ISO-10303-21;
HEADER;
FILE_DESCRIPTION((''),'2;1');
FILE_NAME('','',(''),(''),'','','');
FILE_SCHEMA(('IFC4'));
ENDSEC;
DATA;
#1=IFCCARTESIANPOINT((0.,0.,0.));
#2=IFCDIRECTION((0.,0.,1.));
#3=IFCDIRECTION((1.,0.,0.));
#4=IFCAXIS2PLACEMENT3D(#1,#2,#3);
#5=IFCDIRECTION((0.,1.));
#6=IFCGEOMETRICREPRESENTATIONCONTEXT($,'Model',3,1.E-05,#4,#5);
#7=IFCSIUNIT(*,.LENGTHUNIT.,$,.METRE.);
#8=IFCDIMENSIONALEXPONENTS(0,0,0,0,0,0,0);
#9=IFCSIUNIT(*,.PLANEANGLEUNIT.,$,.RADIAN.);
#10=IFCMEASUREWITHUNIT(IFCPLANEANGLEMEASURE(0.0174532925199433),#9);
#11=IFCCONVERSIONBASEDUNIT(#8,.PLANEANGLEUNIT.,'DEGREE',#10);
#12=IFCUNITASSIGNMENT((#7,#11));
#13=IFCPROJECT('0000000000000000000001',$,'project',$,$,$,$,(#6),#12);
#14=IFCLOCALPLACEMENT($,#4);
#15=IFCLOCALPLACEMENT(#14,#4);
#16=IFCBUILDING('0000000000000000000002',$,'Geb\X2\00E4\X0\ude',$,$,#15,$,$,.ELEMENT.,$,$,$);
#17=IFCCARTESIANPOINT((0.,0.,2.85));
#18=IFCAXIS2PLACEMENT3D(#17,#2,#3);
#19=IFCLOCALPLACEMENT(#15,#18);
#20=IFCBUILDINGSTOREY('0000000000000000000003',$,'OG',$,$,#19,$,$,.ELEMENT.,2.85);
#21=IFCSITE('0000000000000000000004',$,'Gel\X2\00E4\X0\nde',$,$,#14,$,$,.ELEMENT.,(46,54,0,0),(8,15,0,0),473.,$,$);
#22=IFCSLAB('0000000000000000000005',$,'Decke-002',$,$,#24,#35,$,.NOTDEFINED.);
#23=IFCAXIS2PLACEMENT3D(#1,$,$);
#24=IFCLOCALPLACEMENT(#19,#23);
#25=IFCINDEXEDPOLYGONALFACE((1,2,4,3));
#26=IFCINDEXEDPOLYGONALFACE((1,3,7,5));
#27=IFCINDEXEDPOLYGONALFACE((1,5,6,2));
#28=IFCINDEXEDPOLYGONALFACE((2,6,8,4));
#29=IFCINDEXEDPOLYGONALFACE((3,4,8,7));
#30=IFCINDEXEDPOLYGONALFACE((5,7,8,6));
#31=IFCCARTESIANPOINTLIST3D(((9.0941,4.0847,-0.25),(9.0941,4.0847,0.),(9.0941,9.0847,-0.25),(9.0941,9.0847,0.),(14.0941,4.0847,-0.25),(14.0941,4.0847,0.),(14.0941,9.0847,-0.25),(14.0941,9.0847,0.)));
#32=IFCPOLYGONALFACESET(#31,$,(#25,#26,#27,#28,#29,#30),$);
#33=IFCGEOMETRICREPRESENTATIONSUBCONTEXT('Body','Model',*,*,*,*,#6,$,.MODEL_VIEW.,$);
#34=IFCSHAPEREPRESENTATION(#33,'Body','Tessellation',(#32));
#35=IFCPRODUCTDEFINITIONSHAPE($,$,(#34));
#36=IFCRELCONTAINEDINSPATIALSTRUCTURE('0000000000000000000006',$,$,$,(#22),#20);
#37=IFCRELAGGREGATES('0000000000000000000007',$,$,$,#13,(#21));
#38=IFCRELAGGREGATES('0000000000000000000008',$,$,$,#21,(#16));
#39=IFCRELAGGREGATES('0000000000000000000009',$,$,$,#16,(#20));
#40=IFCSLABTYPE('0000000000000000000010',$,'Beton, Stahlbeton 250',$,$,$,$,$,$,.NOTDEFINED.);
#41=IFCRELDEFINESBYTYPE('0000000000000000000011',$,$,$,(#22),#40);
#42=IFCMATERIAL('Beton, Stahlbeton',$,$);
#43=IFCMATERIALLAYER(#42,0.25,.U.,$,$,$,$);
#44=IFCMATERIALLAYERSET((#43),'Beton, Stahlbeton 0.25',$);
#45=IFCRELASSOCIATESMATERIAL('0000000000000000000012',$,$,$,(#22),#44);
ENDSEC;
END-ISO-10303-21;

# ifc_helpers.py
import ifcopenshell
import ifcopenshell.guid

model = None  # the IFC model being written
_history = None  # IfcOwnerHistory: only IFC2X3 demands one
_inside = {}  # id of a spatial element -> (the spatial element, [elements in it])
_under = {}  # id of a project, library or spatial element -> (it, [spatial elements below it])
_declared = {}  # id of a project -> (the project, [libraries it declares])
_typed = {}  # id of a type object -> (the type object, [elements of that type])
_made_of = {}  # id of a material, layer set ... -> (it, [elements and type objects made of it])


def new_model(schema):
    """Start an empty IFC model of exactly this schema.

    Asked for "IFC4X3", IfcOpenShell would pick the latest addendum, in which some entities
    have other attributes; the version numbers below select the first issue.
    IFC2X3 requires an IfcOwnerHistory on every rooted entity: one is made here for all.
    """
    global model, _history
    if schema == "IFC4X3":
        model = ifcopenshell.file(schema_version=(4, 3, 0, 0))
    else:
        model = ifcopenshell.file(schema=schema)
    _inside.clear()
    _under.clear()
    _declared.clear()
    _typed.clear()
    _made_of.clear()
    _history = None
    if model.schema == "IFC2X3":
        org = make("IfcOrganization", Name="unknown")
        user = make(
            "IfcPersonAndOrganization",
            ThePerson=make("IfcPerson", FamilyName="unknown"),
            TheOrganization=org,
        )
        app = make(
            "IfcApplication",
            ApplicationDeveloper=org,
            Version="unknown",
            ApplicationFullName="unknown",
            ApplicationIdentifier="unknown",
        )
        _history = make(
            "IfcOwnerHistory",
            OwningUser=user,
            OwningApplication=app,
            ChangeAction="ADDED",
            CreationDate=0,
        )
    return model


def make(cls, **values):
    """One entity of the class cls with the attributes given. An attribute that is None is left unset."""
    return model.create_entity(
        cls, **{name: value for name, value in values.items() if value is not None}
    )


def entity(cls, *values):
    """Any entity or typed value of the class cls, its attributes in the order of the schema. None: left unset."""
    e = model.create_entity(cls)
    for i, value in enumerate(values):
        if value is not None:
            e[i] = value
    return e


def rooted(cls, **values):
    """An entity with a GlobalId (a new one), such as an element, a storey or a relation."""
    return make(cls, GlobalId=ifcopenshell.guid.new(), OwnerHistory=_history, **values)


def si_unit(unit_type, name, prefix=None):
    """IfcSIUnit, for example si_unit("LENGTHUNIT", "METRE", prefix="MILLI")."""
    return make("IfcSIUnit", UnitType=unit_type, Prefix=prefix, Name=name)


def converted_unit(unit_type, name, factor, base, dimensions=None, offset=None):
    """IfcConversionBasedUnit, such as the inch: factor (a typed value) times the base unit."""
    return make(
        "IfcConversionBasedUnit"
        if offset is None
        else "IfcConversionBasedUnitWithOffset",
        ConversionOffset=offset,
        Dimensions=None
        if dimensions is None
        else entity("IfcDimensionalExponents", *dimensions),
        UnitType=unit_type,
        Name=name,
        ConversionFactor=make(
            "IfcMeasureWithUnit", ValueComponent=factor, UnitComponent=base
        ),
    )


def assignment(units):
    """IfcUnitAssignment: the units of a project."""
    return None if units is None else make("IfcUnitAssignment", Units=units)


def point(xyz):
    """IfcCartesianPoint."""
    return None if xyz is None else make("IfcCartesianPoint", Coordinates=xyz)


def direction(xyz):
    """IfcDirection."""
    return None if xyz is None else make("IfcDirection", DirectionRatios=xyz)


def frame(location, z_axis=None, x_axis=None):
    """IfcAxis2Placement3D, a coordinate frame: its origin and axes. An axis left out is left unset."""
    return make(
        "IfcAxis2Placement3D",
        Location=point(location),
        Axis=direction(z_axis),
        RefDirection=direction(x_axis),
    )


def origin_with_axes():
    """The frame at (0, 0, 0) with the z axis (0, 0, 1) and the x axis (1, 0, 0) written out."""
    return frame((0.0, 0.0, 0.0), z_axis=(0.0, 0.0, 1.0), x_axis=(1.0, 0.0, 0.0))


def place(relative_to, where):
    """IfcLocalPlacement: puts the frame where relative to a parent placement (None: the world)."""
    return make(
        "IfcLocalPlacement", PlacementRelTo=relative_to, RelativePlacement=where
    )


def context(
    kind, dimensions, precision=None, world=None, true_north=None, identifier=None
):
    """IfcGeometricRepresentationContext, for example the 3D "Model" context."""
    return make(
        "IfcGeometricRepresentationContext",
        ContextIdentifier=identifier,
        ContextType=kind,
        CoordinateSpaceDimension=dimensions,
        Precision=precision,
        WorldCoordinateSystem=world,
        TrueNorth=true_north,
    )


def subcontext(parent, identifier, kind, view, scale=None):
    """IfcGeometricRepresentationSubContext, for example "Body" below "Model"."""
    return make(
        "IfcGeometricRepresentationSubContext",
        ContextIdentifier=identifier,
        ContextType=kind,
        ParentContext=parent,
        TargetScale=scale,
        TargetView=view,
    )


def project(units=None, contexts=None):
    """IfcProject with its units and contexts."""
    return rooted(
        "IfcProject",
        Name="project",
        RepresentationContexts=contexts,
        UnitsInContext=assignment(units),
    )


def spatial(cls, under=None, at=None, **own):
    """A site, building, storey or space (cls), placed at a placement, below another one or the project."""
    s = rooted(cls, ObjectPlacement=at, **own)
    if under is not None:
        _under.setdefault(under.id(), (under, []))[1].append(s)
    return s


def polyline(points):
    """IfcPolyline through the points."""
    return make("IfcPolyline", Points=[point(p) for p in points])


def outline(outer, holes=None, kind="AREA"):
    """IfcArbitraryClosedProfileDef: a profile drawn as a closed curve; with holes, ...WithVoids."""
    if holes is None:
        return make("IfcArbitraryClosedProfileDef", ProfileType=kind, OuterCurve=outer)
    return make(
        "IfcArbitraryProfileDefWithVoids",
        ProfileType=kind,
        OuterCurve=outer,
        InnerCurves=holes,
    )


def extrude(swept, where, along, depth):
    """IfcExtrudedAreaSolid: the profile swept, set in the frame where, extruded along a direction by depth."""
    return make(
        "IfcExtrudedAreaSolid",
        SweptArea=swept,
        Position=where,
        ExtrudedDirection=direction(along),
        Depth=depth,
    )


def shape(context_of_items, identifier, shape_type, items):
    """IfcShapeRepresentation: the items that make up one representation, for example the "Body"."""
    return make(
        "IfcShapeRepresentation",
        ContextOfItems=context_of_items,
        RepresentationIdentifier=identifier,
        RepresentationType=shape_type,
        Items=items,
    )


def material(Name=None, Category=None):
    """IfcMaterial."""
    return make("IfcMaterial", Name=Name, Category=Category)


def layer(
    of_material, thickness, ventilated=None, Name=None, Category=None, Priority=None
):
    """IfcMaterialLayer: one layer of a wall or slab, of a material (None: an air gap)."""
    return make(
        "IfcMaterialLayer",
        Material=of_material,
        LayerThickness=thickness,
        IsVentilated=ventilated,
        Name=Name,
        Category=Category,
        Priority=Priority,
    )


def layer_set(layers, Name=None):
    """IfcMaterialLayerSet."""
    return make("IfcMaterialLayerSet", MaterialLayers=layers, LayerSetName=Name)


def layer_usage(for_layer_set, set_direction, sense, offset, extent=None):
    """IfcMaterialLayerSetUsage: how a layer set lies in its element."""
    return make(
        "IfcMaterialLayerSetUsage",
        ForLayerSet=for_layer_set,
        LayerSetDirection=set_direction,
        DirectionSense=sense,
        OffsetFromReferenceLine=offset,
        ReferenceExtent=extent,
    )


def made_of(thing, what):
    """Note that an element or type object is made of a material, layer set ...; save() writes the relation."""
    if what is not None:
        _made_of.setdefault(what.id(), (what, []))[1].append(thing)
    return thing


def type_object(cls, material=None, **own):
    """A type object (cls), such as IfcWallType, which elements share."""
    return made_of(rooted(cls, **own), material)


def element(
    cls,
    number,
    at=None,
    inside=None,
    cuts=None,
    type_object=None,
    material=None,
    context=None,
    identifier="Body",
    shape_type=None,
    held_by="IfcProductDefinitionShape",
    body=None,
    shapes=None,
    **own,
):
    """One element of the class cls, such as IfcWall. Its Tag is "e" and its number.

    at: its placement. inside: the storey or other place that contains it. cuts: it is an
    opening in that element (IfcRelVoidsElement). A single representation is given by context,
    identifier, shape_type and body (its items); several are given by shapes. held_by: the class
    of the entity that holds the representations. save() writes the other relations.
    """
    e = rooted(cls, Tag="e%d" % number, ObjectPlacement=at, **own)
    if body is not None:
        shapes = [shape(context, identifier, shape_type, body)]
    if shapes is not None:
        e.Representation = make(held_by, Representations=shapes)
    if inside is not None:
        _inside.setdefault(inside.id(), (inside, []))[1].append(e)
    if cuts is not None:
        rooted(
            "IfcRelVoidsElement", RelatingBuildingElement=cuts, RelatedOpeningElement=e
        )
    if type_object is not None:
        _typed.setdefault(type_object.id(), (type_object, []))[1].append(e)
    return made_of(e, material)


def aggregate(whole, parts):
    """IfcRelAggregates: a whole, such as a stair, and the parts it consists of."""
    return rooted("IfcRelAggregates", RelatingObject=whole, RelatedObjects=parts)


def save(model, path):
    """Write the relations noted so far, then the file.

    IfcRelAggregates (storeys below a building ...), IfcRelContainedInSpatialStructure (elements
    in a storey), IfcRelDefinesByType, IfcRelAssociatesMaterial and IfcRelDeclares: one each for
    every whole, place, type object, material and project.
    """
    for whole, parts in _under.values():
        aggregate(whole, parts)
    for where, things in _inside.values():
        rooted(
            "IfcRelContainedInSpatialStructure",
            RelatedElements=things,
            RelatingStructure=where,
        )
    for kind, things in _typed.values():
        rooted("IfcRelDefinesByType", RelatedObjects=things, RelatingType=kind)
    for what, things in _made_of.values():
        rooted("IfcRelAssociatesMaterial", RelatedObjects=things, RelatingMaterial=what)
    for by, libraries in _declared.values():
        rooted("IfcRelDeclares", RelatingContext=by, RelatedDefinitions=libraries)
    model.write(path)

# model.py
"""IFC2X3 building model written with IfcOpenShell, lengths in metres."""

from ifc_helpers import new_model, entity, si_unit, converted_unit, direction, frame, origin_with_axes, place, context, subcontext, project, spatial, polyline, outline, extrude, material, layer, layer_set, layer_usage, type_object, element, save


model = new_model("IFC2X3")

# Units and contexts
model_context = context("Model", 3, precision=1e-05, world=origin_with_axes(), true_north=direction((0.0, 1.0)))
body_context = subcontext(model_context, "Body", "Model", "MODEL_VIEW")
ifc_project = project(units=[si_unit("LENGTHUNIT", "METRE"), converted_unit("PLANEANGLEUNIT", "DEGREE", entity("IfcPlaneAngleMeasure", 0.0174532925199433), si_unit("PLANEANGLEUNIT", "RADIAN"), dimensions=[0, 0, 0, 0, 0, 0, 0])], contexts=[model_context])

# Site, building, storey
site_placement = place(None, origin_with_axes())
site = spatial("IfcSite", under=ifc_project, at=site_placement, Name="Gelände", CompositionType="ELEMENT", RefLatitude=(46, 54, 0, 0), RefLongitude=(8, 15, 0, 0), RefElevation=473.0)
building_placement = place(site_placement, origin_with_axes())
building = spatial("IfcBuilding", under=site, at=building_placement, Name="Gebäude", CompositionType="ELEMENT")
storey_placement = place(building_placement, frame((0.0, 0.0, 2.85), z_axis=(0.0, 0.0, 1.0), x_axis=(1.0, 0.0, 0.0)))
storey = spatial("IfcBuildingStorey", under=building, at=storey_placement, Name="OG", CompositionType="ELEMENT", Elevation=2.85)

# Slab
ifc_material = material(Name="Beton, Stahlbeton")
ifc_layer = layer(ifc_material, 0.25, ventilated="UNKNOWN")
ifc_layer_set = layer_set([ifc_layer], Name="Beton, Stahlbeton 0.25")
ifc_layer_usage = layer_usage(ifc_layer_set, "AXIS3", "NEGATIVE", 0.25)
slab_type = type_object("IfcSlabType", Name="Beton, Stahlbeton 250", PredefinedType="NOTDEFINED")
slab_placement = place(storey_placement, frame((9.0941, 4.0847, 0.0), z_axis=(0.0, 0.0, 1.0), x_axis=(1.0, 0.0, 0.0)))
element("IfcSlab", 1, at=slab_placement, inside=storey, type_object=slab_type, material=ifc_layer_usage, Name="Decke-002", PredefinedType="NOTDEFINED", context=body_context, shape_type="SweptSolid", body=[
    extrude(outline(polyline([(0.0, 0.0), (5.0, 0.0), (5.0, 5.0), (0.0, 5.0), (0.0, 0.0)])), frame((0.0, 0.0, -0.25), z_axis=(0.0, 0.0, 1.0), x_axis=(1.0, 0.0, 0.0)), (0.0, 0.0, 1.0), 0.25),
])

save(model, "model.ifc")
